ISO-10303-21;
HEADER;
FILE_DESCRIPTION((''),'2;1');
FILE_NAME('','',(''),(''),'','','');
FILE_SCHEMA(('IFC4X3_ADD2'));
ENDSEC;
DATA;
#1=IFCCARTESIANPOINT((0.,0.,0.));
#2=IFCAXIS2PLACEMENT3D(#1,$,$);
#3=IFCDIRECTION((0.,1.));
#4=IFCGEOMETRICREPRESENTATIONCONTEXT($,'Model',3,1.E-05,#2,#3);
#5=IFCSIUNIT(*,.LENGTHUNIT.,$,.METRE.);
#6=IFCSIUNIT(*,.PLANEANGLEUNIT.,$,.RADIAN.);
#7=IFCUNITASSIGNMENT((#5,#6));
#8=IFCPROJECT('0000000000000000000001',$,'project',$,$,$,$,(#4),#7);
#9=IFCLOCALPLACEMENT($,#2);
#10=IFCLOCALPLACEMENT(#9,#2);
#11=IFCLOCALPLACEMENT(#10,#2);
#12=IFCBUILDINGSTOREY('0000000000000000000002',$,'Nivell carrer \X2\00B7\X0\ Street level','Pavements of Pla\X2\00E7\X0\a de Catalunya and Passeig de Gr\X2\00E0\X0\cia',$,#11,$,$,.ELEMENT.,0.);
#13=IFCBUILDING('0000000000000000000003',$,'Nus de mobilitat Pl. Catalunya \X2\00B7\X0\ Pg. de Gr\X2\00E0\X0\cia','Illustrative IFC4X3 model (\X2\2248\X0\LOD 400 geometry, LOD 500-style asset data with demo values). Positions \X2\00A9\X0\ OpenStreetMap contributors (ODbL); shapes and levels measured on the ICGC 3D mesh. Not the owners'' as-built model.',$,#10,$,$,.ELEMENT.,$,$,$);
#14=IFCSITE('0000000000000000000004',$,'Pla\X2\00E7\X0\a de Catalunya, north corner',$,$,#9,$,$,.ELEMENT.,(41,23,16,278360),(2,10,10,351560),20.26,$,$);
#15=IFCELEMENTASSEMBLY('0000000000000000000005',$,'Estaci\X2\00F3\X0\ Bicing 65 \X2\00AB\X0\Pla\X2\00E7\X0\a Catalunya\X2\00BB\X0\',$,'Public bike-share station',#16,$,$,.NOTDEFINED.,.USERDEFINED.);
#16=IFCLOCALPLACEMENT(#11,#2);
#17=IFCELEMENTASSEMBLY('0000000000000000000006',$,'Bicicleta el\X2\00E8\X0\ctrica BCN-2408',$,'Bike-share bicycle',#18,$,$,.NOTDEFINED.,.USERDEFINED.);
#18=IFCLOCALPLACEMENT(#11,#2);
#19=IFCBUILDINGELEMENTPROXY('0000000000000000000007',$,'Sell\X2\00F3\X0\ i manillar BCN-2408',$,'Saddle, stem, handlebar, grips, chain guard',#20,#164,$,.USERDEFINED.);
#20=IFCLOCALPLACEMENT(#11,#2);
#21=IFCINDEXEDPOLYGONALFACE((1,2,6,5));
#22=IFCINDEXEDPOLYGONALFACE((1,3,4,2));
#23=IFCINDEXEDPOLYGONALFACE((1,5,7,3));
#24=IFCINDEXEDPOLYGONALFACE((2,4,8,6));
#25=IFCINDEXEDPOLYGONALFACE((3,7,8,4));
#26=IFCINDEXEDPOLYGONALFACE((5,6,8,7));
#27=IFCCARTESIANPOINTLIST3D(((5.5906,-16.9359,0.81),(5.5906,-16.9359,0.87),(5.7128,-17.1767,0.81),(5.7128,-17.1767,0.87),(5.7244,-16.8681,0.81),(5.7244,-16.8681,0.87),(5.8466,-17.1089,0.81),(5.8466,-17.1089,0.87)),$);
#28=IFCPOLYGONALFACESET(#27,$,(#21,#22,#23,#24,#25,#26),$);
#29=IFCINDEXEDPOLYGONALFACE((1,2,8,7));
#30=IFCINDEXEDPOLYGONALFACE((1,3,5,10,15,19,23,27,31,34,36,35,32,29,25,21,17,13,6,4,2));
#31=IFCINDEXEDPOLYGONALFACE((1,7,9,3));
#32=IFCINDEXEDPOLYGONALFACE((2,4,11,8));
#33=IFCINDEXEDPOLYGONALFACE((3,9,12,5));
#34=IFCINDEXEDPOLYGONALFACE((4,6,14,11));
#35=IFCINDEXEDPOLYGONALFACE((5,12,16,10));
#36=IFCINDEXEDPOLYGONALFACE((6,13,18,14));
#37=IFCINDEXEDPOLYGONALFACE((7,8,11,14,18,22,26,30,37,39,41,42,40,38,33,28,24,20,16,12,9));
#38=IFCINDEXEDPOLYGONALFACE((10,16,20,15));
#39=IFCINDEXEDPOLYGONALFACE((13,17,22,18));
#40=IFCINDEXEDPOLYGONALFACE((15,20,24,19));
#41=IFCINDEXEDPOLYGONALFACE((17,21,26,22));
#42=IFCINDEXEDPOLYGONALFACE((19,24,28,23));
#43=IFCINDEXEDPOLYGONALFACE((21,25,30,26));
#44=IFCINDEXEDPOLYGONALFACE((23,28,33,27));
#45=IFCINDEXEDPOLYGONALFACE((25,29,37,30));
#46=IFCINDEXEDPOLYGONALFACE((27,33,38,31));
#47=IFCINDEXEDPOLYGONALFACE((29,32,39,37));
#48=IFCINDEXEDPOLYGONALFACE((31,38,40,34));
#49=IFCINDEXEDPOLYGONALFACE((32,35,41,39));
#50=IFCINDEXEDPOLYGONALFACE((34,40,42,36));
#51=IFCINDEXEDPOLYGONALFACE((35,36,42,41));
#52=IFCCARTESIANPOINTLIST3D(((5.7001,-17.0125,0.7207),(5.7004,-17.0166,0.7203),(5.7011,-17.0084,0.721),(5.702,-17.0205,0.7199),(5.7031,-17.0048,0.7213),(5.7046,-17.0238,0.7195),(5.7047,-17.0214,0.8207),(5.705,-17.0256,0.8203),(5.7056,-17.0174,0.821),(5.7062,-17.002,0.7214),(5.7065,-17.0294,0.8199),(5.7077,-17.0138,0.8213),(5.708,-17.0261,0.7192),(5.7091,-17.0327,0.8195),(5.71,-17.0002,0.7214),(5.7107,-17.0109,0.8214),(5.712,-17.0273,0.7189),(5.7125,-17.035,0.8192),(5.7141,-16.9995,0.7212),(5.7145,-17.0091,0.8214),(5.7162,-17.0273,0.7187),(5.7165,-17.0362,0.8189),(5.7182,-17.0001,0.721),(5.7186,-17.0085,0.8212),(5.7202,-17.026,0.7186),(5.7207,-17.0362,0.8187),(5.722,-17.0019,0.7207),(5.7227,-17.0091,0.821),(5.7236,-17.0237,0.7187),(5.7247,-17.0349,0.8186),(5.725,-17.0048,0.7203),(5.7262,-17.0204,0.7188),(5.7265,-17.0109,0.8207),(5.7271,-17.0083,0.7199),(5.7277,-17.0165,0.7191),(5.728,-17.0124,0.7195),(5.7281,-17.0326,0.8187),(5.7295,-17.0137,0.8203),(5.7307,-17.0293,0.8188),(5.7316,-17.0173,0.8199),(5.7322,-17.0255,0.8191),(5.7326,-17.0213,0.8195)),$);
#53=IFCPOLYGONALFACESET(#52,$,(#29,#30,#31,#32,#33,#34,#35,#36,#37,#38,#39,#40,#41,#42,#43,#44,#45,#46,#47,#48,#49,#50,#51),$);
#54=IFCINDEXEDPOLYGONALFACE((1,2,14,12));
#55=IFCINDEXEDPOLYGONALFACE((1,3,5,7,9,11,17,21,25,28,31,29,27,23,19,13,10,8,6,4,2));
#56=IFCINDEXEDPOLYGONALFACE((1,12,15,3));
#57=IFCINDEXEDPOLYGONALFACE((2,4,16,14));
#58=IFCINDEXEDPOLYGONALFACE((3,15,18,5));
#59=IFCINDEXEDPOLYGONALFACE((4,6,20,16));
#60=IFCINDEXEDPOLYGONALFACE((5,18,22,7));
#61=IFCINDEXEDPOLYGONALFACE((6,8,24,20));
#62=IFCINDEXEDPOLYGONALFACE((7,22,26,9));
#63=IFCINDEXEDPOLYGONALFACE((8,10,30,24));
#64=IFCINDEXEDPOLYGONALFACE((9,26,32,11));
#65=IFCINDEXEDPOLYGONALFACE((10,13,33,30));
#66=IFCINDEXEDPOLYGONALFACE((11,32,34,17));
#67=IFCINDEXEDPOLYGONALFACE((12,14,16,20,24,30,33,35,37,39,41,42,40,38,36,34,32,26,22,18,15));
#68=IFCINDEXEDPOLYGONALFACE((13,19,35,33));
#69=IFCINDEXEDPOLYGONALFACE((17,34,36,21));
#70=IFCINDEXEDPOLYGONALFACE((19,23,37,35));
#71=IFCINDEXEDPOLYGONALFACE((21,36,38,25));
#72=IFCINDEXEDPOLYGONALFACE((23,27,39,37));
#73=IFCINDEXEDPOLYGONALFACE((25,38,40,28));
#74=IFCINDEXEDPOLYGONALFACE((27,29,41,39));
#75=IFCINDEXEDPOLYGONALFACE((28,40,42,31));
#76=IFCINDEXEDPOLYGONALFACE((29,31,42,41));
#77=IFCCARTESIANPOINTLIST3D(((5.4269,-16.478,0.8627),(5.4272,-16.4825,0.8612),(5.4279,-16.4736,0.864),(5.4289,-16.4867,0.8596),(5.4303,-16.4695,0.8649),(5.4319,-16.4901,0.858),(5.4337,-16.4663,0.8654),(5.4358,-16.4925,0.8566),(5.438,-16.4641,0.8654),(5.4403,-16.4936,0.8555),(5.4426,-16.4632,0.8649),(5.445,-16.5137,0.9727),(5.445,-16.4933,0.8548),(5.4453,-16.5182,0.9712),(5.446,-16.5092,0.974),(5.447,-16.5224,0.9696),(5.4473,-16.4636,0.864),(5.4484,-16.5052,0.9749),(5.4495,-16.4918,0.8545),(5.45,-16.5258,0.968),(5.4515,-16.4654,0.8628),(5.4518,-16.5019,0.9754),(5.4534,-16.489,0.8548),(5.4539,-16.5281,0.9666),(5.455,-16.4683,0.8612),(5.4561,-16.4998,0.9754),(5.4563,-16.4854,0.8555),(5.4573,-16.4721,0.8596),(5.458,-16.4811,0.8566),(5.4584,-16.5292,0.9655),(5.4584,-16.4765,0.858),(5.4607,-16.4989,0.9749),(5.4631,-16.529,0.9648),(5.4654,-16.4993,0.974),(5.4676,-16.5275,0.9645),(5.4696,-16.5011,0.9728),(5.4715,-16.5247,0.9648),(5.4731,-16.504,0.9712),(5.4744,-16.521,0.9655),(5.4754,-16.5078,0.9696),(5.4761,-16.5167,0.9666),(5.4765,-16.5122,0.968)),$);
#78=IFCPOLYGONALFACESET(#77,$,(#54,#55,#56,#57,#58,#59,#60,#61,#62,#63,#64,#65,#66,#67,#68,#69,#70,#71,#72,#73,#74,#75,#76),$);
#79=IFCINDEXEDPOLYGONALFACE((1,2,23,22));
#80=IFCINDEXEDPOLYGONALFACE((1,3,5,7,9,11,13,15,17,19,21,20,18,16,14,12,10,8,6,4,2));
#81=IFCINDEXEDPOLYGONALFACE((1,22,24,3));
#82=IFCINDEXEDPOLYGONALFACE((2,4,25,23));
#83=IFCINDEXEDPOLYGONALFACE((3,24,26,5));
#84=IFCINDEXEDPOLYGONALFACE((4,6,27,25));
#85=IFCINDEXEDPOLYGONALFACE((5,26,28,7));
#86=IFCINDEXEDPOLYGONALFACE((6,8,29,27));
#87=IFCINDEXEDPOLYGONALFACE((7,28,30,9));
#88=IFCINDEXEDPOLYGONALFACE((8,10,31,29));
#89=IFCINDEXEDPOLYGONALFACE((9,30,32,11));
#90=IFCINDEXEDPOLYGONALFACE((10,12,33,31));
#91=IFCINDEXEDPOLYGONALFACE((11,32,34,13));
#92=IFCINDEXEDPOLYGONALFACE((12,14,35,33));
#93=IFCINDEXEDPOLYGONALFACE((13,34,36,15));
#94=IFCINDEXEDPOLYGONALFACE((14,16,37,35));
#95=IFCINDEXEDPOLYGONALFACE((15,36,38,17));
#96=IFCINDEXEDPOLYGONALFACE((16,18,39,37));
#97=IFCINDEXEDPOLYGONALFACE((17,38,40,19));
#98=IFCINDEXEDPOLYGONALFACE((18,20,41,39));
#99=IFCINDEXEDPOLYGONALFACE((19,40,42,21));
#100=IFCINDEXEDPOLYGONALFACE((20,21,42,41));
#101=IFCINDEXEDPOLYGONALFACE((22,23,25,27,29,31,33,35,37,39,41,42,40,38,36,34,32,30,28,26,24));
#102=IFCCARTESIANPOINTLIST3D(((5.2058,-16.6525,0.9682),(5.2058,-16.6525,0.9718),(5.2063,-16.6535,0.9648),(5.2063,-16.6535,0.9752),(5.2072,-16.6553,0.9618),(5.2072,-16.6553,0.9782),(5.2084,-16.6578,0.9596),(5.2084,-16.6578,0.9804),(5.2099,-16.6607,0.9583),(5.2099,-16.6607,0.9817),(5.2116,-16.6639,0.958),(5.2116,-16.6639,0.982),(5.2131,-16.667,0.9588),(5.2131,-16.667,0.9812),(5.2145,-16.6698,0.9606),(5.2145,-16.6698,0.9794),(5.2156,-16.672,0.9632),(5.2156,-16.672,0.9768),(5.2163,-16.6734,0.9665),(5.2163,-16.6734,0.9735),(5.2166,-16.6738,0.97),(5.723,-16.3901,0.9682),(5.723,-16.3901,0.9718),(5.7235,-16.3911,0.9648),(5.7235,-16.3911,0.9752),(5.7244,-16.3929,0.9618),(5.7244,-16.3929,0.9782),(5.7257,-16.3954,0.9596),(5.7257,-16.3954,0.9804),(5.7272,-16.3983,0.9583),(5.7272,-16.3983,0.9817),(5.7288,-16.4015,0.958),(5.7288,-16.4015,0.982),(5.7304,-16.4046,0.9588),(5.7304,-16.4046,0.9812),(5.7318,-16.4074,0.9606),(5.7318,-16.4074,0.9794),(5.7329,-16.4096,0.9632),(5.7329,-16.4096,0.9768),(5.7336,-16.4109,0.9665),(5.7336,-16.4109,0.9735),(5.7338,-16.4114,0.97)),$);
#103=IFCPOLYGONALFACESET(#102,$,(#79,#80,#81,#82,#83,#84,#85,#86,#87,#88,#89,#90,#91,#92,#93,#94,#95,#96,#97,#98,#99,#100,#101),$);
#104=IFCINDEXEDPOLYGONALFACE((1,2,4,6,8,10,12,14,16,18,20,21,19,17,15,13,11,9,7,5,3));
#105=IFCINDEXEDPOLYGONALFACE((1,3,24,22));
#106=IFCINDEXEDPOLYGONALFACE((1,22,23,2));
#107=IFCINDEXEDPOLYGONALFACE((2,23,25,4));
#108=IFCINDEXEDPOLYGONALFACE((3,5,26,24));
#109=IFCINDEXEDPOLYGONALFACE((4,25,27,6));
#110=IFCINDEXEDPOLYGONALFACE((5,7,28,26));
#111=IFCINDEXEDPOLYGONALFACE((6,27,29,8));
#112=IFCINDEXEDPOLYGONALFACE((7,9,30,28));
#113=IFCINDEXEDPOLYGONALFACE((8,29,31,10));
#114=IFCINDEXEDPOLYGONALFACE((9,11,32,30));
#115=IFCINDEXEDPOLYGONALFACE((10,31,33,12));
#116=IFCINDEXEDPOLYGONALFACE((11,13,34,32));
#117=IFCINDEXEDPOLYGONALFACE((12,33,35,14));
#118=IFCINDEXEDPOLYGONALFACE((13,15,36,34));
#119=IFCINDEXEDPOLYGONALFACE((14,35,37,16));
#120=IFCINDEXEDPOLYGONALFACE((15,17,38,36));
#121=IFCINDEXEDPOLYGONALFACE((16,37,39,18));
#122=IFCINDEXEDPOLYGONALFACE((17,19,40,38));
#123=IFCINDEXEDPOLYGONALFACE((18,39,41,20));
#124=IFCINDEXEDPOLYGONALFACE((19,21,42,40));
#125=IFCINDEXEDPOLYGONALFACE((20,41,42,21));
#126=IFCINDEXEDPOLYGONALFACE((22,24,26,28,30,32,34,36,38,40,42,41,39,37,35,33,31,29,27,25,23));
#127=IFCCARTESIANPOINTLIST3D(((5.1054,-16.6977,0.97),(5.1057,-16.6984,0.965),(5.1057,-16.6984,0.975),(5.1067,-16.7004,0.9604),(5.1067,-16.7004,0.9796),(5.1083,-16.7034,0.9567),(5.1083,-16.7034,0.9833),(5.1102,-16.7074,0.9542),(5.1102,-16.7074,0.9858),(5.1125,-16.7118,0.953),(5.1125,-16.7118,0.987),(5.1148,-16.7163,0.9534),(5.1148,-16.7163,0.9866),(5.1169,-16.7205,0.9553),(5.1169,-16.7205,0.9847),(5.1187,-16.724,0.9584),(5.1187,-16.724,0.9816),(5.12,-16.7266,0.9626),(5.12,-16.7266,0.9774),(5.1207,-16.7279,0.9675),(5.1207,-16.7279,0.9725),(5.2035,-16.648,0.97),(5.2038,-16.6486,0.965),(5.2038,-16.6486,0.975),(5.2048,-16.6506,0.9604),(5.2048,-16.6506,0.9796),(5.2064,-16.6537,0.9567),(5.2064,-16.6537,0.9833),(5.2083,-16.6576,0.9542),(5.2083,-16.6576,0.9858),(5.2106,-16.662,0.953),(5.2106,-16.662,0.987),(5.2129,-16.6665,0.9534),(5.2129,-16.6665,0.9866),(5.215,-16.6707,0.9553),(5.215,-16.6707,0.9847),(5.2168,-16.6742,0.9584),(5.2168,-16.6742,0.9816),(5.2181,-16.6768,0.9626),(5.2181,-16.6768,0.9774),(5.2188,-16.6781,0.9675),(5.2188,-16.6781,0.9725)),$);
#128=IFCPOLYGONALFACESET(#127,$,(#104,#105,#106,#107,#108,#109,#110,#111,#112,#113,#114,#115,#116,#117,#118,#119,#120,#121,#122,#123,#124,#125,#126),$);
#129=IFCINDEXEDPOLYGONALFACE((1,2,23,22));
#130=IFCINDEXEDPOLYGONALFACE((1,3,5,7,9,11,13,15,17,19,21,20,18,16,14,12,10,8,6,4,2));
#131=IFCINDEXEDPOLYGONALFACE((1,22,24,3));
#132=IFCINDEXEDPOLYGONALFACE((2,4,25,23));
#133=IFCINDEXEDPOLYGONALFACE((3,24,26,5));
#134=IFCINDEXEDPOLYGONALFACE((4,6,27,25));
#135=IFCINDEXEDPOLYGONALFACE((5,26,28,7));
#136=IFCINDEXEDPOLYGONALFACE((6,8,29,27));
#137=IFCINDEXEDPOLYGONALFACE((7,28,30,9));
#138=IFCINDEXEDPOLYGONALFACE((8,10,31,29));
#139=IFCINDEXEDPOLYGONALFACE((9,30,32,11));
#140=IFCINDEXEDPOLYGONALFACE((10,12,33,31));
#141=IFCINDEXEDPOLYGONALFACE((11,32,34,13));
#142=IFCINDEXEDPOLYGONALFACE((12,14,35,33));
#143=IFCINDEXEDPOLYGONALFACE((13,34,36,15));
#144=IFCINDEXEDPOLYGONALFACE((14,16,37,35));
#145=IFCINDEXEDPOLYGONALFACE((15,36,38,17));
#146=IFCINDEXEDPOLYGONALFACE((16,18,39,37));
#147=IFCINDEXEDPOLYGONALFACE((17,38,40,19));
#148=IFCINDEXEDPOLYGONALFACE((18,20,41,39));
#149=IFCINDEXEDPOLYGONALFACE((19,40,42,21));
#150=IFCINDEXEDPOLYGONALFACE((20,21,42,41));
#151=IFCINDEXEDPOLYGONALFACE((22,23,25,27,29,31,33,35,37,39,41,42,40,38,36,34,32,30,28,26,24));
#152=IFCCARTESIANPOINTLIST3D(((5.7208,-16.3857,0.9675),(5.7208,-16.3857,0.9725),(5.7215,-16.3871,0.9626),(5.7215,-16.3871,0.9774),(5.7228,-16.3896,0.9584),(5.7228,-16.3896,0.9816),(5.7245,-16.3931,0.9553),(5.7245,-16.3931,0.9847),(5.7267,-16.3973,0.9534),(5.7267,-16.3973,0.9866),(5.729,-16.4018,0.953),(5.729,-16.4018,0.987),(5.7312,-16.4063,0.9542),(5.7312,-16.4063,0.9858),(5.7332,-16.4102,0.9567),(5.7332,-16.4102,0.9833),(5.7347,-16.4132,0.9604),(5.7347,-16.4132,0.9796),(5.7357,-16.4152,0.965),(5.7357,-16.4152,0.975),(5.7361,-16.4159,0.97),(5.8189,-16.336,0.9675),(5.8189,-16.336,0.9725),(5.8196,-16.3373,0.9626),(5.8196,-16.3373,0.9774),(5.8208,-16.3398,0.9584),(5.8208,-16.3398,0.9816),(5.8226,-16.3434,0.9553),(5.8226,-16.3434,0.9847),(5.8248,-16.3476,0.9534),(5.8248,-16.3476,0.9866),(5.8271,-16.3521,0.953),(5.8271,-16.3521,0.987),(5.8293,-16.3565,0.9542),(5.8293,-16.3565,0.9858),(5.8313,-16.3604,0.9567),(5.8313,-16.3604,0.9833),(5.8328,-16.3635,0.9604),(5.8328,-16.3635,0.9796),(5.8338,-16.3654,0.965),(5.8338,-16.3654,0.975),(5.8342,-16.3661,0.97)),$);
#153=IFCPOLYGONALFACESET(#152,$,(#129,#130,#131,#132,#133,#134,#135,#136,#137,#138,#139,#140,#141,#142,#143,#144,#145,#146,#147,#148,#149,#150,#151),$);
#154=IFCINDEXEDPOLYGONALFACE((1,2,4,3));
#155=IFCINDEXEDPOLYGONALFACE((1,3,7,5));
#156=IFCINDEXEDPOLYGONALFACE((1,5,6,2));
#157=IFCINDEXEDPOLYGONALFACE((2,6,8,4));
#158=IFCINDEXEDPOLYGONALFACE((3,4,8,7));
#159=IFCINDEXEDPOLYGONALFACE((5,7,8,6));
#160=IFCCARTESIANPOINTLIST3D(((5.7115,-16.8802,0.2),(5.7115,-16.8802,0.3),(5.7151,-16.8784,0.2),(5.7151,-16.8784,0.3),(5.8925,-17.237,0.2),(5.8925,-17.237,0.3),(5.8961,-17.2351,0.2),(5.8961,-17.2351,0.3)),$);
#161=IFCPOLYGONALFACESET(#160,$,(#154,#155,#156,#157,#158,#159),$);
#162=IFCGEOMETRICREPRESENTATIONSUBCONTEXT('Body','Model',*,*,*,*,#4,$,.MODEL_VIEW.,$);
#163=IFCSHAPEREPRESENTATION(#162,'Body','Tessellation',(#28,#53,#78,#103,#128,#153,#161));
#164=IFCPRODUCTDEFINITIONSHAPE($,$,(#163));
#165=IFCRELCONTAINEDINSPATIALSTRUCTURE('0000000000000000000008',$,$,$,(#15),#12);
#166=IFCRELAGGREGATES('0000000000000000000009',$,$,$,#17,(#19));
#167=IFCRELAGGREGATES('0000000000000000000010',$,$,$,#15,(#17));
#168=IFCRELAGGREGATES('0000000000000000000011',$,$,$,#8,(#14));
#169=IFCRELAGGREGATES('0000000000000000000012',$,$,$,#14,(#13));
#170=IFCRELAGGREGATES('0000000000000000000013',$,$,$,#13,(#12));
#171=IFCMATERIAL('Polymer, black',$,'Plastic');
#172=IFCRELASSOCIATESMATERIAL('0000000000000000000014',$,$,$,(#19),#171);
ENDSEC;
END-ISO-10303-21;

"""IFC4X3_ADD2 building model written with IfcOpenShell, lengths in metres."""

from ifc_helpers import new_model, si_unit, direction, frame, origin, origin_2d_with_axis, place, context, subcontext, project, spatial, rectangle, circle, extrude, material, element, aggregate, save


model = new_model("IFC4X3_ADD2")

# Units and contexts
model_context = context("Model", 3, precision=1e-05, world=origin(), true_north=direction((0.0, 1.0)))
body_context = subcontext(model_context, "Body", "Model", "MODEL_VIEW")
ifc_project = project(units=[si_unit("LENGTHUNIT", "METRE"), si_unit("PLANEANGLEUNIT", "RADIAN")], contexts=[model_context])

# Site, building, storey
site_placement = place(None, origin())
site = spatial("IfcSite", under=ifc_project, at=site_placement, Name="Plaça de Catalunya, north corner", CompositionType="ELEMENT", RefLatitude=(41, 23, 16, 278360), RefLongitude=(2, 10, 10, 351560), RefElevation=20.26)
building_placement = place(site_placement, origin())
building = spatial("IfcBuilding", under=site, at=building_placement, Name="Nus de mobilitat Pl. Catalunya · Pg. de Gràcia", Description="Illustrative IFC4X3 model (≈LOD 400 geometry, LOD 500-style asset data with demo values). Positions © OpenStreetMap contributors (ODbL); shapes and levels measured on the ICGC 3D mesh. Not the owners' as-built model.", CompositionType="ELEMENT")
storey_placement = place(building_placement, origin())
storey = spatial("IfcBuildingStorey", under=building, at=storey_placement, Name="Nivell carrer · Street level", Description="Pavements of Plaça de Catalunya and Passeig de Gràcia", CompositionType="ELEMENT", Elevation=0.0)

# Element assemblies, building element proxy
assembly_1_placement = place(building_placement, origin())
assembly_1 = element("IfcElementAssembly", 1, at=assembly_1_placement, inside=storey, Name="Estació Bicing 65 «Plaça Catalunya»", ObjectType="Public bike-share station", AssemblyPlace="NOTDEFINED", PredefinedType="USERDEFINED")
assembly_2_placement = place(building_placement, origin())
assembly_2 = element("IfcElementAssembly", 2, at=assembly_2_placement, Name="Bicicleta elèctrica BCN-2408", ObjectType="Bike-share bicycle", AssemblyPlace="NOTDEFINED", PredefinedType="USERDEFINED")
ifc_material_1 = material(Name="Polymer, black", Category="Plastic")
proxy_1_placement = place(building_placement, origin())
proxy_1 = element("IfcBuildingElementProxy", 3, at=proxy_1_placement, material=ifc_material_1, Name="Selló i manillar BCN-2408", ObjectType="Saddle, stem, handlebar, grips, chain guard", PredefinedType="USERDEFINED", context=body_context, shape_type="SweptSolid", body=[
    extrude(rectangle(XDim=0.27, YDim=0.15, at=origin_2d_with_axis()), frame((5.7186, -17.0224, 0.87), z_axis=(0.0, 0.0, -1.0), x_axis=(-0.452435, 0.891798, 0.0)), (0.0, 0.0, 1.0), 0.06),
    extrude(circle(Radius=0.014, at=origin_2d_with_axis()), frame((5.7141, -17.0135, 0.72), z_axis=(0.045019, -0.088737, 0.995037), x_axis=(0.0, 0.996047, 0.088827)), (0.0, 0.0, 1.0), 0.1005),
    extrude(circle(Radius=0.016, at=origin_2d_with_axis()), frame((5.4426, -16.4784, 0.86), z_axis=(0.154616, -0.304766, 0.939793), x_axis=(0.0, 0.951232, 0.308475)), (0.0, 0.0, 1.0), 0.117),
    extrude(circle(Radius=0.012, at=origin_2d_with_axis()), frame((5.2111, -16.6631, 0.97), z_axis=(0.891798, 0.452435, 0.0), x_axis=(0.452435, -0.891798, 0.0)), (0.0, 0.0, 1.0), 0.58),
    extrude(circle(Radius=0.017, at=origin_2d_with_axis()), frame((5.2111, -16.6631, 0.97), z_axis=(-0.891798, -0.452435, 0.0), x_axis=(-0.452435, 0.891798, 0.0)), (0.0, 0.0, 1.0), 0.11),
    extrude(circle(Radius=0.017, at=origin_2d_with_axis()), frame((5.7284, -16.4007, 0.97), z_axis=(0.891798, 0.452435, 0.0), x_axis=(0.452435, -0.891798, 0.0)), (0.0, 0.0, 1.0), 0.11),
    extrude(rectangle(XDim=0.4, YDim=0.1, at=origin_2d_with_axis()), frame((5.802, -17.0586, 0.25), z_axis=(0.891798, 0.452435, 0.0), x_axis=(-0.452435, 0.891798, 0.0)), (0.0, 0.0, 1.0), 0.004),
])
aggregate(assembly_2, [proxy_1])
aggregate(assembly_1, [assembly_2])

save(model, "model.ifc")
